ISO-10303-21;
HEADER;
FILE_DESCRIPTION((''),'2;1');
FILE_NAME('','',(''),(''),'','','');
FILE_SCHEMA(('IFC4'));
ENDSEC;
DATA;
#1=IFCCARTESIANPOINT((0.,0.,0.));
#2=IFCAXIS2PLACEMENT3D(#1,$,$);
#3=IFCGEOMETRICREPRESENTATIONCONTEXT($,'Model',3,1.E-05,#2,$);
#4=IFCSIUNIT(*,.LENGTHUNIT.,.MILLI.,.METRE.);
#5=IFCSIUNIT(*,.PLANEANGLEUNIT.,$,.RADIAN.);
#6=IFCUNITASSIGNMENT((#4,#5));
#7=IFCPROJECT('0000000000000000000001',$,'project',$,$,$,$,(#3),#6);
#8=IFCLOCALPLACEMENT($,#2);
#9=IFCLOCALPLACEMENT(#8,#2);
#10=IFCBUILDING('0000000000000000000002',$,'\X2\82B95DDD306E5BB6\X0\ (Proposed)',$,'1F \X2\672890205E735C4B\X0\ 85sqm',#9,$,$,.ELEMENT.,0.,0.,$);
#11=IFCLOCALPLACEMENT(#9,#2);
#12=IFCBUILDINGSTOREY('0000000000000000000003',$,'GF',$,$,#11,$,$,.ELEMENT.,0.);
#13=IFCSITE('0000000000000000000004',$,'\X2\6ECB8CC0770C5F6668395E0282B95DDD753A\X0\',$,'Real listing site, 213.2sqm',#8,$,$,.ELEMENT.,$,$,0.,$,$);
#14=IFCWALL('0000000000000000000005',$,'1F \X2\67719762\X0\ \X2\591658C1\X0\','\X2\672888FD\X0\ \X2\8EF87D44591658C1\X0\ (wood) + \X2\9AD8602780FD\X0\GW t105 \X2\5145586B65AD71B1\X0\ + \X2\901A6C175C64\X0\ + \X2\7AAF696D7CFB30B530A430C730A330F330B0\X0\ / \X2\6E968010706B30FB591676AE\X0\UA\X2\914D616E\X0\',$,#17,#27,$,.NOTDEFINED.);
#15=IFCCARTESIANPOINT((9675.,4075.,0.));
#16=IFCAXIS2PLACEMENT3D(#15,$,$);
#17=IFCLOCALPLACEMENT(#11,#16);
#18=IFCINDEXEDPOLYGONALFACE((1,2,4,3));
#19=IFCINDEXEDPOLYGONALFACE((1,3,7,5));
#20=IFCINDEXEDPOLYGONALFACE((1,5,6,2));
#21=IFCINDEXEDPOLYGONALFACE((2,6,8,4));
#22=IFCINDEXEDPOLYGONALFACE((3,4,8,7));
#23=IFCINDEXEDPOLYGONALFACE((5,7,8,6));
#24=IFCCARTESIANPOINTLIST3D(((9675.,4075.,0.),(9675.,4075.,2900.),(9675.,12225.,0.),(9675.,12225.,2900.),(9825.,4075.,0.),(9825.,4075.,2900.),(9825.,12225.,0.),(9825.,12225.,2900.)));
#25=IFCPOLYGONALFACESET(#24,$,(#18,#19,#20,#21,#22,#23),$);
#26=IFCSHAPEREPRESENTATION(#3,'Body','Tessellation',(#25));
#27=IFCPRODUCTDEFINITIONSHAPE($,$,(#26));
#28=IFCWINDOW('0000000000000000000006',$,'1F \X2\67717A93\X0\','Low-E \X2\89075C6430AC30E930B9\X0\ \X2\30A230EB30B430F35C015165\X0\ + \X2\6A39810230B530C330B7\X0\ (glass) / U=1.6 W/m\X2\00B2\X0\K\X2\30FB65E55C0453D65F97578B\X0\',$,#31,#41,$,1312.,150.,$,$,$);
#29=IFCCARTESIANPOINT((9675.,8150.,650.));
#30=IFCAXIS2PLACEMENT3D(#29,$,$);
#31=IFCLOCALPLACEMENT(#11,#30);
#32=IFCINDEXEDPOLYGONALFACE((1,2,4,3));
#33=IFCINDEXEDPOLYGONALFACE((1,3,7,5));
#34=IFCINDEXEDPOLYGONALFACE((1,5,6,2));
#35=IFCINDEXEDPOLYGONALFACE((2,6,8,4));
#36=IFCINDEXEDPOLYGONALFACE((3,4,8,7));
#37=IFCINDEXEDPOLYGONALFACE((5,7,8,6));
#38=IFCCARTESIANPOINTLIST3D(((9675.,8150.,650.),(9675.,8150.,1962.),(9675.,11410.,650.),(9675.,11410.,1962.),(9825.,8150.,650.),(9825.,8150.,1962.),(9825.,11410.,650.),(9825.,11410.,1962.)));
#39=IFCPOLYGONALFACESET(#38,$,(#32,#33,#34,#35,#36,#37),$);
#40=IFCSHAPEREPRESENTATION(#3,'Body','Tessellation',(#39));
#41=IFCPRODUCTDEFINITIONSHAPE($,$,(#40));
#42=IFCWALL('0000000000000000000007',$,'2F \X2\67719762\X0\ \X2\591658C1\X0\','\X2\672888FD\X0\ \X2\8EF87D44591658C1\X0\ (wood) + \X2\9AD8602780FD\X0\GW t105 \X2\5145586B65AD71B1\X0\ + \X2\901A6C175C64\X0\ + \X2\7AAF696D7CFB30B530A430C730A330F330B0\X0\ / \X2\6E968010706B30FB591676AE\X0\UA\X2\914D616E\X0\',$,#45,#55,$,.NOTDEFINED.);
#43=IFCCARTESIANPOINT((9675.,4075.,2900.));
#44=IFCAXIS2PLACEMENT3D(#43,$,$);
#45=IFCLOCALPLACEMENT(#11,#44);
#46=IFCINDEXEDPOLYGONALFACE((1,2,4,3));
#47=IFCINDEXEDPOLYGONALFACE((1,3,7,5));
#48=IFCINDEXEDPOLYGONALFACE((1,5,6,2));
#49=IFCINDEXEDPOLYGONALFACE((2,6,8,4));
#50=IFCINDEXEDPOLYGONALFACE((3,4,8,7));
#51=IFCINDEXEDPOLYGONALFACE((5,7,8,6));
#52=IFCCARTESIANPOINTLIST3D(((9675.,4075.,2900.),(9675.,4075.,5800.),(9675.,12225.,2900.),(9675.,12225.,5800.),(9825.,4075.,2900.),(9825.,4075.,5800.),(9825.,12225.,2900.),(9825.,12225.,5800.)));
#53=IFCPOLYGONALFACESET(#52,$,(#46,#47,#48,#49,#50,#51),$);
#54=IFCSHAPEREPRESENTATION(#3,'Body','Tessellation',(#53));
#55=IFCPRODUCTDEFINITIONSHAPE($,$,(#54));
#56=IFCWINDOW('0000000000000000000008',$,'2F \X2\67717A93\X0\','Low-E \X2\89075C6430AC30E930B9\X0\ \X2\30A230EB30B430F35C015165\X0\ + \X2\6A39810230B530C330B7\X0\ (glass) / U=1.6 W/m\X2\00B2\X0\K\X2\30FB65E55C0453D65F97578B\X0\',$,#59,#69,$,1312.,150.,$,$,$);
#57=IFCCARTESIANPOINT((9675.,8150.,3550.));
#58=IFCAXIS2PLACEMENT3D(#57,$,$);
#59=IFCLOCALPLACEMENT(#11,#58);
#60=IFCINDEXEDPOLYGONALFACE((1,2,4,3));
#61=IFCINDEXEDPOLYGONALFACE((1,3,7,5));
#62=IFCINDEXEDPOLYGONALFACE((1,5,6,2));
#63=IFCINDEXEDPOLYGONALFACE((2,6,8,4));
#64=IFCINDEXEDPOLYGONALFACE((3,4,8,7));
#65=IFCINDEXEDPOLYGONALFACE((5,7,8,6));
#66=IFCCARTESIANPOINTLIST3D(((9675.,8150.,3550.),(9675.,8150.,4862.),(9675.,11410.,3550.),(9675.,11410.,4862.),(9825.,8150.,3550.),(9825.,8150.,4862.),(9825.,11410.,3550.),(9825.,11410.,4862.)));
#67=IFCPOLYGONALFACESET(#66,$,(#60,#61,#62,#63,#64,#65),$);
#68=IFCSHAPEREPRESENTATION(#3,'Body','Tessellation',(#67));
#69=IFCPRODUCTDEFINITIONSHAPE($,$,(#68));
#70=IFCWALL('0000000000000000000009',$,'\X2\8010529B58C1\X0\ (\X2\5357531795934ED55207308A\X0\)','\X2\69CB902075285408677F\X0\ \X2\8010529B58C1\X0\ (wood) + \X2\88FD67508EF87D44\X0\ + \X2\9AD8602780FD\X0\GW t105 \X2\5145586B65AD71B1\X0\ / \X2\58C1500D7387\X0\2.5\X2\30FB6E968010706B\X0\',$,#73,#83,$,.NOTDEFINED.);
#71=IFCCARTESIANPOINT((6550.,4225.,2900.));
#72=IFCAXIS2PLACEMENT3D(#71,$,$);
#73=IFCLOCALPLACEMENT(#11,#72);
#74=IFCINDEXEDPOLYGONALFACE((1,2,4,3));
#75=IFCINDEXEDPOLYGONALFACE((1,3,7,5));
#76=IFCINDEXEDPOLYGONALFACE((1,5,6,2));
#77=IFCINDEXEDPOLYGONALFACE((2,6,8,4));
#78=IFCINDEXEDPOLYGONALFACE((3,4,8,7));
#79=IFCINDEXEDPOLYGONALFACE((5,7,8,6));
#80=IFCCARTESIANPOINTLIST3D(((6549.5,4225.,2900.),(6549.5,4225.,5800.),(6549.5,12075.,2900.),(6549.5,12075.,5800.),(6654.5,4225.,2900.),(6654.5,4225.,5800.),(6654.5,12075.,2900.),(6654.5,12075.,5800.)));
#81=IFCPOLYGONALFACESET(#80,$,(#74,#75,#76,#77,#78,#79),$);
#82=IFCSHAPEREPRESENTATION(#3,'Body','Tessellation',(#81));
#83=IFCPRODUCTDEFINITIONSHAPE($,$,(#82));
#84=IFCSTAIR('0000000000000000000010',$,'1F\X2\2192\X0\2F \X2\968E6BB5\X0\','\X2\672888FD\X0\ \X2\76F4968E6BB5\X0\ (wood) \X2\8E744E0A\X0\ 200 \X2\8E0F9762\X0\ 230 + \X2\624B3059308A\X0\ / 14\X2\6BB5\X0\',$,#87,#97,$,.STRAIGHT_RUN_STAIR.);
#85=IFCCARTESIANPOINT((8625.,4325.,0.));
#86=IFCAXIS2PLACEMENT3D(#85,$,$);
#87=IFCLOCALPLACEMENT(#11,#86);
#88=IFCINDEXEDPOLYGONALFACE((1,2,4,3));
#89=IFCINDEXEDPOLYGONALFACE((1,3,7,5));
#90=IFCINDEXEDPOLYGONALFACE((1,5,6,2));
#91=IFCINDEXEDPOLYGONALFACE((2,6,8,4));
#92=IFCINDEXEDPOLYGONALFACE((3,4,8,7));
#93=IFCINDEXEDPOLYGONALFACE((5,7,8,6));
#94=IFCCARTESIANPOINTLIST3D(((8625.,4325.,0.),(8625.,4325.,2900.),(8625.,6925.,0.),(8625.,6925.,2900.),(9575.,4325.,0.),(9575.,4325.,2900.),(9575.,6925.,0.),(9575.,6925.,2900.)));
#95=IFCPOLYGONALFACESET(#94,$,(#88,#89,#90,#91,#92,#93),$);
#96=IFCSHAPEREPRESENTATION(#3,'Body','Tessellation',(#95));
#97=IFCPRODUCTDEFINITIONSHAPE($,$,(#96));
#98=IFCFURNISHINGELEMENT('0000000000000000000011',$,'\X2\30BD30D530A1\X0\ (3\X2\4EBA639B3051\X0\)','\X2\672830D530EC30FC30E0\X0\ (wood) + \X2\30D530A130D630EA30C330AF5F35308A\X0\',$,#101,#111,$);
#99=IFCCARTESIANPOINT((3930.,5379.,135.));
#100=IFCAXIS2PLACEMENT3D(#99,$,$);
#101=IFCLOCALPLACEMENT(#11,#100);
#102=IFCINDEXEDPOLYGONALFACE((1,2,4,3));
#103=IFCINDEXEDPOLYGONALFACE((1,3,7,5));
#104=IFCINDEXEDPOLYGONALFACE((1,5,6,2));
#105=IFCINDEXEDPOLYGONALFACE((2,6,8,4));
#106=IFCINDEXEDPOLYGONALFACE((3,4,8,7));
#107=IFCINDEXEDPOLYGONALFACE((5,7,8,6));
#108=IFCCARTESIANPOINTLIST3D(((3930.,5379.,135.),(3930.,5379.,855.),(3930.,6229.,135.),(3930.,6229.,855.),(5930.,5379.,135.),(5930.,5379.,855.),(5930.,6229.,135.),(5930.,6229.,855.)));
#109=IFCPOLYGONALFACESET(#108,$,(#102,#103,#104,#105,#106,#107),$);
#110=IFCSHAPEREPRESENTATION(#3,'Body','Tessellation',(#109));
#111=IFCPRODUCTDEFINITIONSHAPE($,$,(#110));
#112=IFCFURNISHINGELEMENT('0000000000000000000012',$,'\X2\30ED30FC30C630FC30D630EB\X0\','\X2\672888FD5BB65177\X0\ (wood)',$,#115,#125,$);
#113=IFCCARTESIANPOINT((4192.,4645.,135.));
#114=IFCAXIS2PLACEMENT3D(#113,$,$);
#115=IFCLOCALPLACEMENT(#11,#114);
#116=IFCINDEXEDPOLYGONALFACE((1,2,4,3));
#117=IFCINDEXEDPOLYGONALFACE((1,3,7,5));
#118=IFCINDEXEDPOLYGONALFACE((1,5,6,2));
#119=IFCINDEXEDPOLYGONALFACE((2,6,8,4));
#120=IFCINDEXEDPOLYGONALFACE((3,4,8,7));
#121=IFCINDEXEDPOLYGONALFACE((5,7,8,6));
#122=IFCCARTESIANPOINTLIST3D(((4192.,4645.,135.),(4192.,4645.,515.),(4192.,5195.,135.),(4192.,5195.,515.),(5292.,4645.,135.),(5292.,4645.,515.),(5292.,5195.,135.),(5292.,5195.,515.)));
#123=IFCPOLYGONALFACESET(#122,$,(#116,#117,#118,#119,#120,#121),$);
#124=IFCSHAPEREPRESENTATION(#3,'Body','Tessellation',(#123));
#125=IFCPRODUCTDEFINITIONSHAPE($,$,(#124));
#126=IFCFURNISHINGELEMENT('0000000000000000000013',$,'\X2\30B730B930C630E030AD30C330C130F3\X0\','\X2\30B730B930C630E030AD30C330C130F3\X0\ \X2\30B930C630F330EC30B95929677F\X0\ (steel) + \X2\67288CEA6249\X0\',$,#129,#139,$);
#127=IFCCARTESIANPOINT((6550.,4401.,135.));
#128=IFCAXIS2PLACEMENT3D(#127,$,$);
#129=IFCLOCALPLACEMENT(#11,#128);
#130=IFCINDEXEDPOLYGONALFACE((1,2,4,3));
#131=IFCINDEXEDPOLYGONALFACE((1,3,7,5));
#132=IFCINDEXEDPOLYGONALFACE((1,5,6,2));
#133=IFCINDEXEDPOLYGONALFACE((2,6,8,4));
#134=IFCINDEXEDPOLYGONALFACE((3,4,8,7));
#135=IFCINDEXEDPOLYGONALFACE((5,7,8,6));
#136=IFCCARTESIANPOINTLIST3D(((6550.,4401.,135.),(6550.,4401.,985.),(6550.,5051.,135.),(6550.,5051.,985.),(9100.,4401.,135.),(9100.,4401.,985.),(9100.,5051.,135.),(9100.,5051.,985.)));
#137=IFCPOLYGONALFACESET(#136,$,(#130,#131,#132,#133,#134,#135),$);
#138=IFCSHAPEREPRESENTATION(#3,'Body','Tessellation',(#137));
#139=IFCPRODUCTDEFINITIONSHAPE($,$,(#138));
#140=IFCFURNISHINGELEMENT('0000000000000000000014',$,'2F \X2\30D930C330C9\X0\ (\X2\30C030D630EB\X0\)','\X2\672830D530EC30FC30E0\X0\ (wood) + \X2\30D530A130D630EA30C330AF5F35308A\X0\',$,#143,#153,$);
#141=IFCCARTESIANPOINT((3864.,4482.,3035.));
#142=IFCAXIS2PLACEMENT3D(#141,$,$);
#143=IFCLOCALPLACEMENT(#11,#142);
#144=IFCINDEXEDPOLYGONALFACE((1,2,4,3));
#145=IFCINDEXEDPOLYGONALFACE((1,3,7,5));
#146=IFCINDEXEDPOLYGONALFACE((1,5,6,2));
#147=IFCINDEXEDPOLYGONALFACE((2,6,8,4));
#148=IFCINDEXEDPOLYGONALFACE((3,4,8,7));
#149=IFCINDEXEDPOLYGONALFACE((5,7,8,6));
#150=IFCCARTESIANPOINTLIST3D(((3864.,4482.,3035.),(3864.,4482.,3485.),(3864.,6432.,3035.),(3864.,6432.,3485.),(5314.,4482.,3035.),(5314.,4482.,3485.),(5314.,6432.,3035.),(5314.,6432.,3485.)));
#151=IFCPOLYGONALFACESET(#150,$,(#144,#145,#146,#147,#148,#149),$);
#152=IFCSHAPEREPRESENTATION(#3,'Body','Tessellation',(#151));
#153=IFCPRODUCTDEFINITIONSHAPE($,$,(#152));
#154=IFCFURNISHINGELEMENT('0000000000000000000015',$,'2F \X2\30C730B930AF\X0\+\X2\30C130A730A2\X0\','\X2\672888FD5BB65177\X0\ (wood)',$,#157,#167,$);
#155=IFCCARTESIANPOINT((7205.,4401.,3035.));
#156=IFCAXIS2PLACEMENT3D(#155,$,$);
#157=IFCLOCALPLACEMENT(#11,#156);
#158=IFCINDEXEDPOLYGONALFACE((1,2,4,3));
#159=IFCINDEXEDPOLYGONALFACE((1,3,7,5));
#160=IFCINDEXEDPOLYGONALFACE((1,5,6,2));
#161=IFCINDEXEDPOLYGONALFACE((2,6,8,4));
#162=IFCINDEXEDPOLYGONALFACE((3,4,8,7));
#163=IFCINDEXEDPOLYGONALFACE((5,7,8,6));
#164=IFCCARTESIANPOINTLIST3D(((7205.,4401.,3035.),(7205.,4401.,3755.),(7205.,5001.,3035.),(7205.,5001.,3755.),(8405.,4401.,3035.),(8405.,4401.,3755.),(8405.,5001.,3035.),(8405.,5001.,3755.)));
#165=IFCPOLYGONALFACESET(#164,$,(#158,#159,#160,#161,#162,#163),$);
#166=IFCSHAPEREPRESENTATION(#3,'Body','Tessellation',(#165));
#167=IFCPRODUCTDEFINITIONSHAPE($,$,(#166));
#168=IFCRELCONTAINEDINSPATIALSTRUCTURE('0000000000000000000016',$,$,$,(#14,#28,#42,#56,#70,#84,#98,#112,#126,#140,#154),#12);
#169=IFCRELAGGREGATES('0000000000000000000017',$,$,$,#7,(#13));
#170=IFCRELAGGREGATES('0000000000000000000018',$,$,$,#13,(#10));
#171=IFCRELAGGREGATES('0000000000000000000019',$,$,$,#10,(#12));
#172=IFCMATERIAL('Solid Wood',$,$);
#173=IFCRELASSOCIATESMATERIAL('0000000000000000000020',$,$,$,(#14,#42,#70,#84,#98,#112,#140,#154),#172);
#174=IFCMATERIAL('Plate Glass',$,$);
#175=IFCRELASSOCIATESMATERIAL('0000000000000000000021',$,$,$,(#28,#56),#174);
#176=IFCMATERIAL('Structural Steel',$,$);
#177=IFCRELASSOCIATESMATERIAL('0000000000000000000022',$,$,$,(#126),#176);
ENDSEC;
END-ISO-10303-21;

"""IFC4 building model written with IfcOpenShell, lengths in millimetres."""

from ifc_helpers import new_model, si_unit, frame, frame_2d, origin, place, context, project, spatial, rectangle, extrude, material, element, fill, save


model = new_model("IFC4")

# Units and contexts
model_context = context("Model", 3, precision=1e-05, world=origin())
ifc_project = project(units=[si_unit("LENGTHUNIT", "METRE", prefix="MILLI"), si_unit("PLANEANGLEUNIT", "RADIAN")], contexts=[model_context])

# Site, building, storey
site_placement = place(None, origin())
site = spatial("IfcSite", under=ifc_project, at=site_placement, Name="滋賀県彦根市芹川町", ObjectType="Real listing site, 213.2sqm", CompositionType="ELEMENT", RefElevation=0.0)
building_placement = place(site_placement, origin())
building = spatial("IfcBuilding", under=site, at=building_placement, Name="芹川の家 (Proposed)", ObjectType="1F 木造平屋 85sqm", CompositionType="ELEMENT", ElevationOfRefHeight=0.0, ElevationOfTerrain=0.0)
storey_placement = place(building_placement, origin())
storey = spatial("IfcBuildingStorey", under=building, at=storey_placement, Name="GF", CompositionType="ELEMENT", Elevation=0.0)

# Wall, opening, window
ifc_material_1 = material(Name="Solid Wood")
wall_1_placement = place(storey_placement, frame((9675.0, 4075.0, 0.0)))
wall_1 = element("IfcWall", 1, at=wall_1_placement, inside=storey, material=ifc_material_1, Name="1F 東面 外壁", Description="木製 軸組外壁 (wood) + 高性能GW t105 充填断熱 + 通気層 + 窯業系サイディング / 準耐火・外皮UA配慮", PredefinedType="NOTDEFINED", context=model_context, shape_type="SweptSolid", body=[
    extrude(rectangle(XDim=150.0, YDim=8150.0, at=frame_2d((75.0, 4075.0))), frame((9675.0, 4075.0, 0.0)), (0.0, 0.0, 1.0), 2900.0),
])
opening_1_placement = place(storey_placement, frame((9675.0, 8150.0, 650.0)))
opening_1 = element("IfcOpeningElement", 2, at=opening_1_placement, cuts=wall_1, PredefinedType="NOTDEFINED", context=model_context, shape_type="SweptSolid", body=[
    extrude(rectangle(XDim=150.0, YDim=3260.0, at=frame_2d((75.0, 1630.0))), frame((9675.0, 8150.0, 650.0)), (0.0, 0.0, 1.0), 1312.0),
])
ifc_material_2 = material(Name="Plate Glass")
window_1_placement = place(storey_placement, frame((9675.0, 8150.0, 650.0)))
window_1 = element("IfcWindow", 3, at=window_1_placement, inside=storey, material=ifc_material_2, Name="1F 東窓", Description="Low-E 複層ガラス アルゴン封入 + 樹脂サッシ (glass) / U=1.6 W/m²K・日射取得型", OverallHeight=1312.0, OverallWidth=150.0, context=model_context, shape_type="SweptSolid", body=[
    extrude(rectangle(XDim=150.0, YDim=3260.0, at=frame_2d((75.0, 1630.0))), frame((9675.0, 8150.0, 650.0)), (0.0, 0.0, 1.0), 1312.0),
])
fill(opening_1, window_1)

# Wall, opening, window
wall_2_placement = place(storey_placement, frame((9675.0, 4075.0, 2900.0)))
wall_2 = element("IfcWall", 4, at=wall_2_placement, inside=storey, material=ifc_material_1, Name="2F 東面 外壁", Description="木製 軸組外壁 (wood) + 高性能GW t105 充填断熱 + 通気層 + 窯業系サイディング / 準耐火・外皮UA配慮", PredefinedType="NOTDEFINED", context=model_context, shape_type="SweptSolid", body=[
    extrude(rectangle(XDim=150.0, YDim=8150.0, at=frame_2d((75.0, 4075.0))), frame((9675.0, 4075.0, 2900.0)), (0.0, 0.0, 1.0), 2900.0),
])
opening_2_placement = place(storey_placement, frame((9675.0, 8150.0, 3550.0)))
opening_2 = element("IfcOpeningElement", 5, at=opening_2_placement, cuts=wall_2, PredefinedType="NOTDEFINED", context=model_context, shape_type="SweptSolid", body=[
    extrude(rectangle(XDim=150.0, YDim=3260.0, at=frame_2d((75.0, 1630.0))), frame((9675.0, 8150.0, 3550.0)), (0.0, 0.0, 1.0), 1312.0),
])
window_2_placement = place(storey_placement, frame((9675.0, 8150.0, 3550.0)))
window_2 = element("IfcWindow", 6, at=window_2_placement, inside=storey, material=ifc_material_2, Name="2F 東窓", Description="Low-E 複層ガラス アルゴン封入 + 樹脂サッシ (glass) / U=1.6 W/m²K・日射取得型", OverallHeight=1312.0, OverallWidth=150.0, context=model_context, shape_type="SweptSolid", body=[
    extrude(rectangle(XDim=150.0, YDim=3260.0, at=frame_2d((75.0, 1630.0))), frame((9675.0, 8150.0, 3550.0)), (0.0, 0.0, 1.0), 1312.0),
])
fill(opening_2, window_2)

# Wall
wall_3_placement = place(storey_placement, frame((6550.0, 4225.0, 2900.0)))
element("IfcWall", 7, at=wall_3_placement, inside=storey, material=ifc_material_1, Name="耐力壁 (南北間仕切り)", Description="構造用合板 耐力壁 (wood) + 製材軸組 + 高性能GW t105 充填断熱 / 壁倍率2.5・準耐火", PredefinedType="NOTDEFINED", context=model_context, shape_type="SweptSolid", body=[
    extrude(rectangle(XDim=105.0, YDim=7850.0, at=frame_2d((52.0, 3925.0))), frame((6550.0, 4225.0, 2900.0)), (0.0, 0.0, 1.0), 2900.0),
])

# Stair
stair_placement = place(storey_placement, frame((8625.0, 4325.0, 0.0)))
element("IfcStair", 8, at=stair_placement, inside=storey, material=ifc_material_1, Name="1F→2F 階段", Description="木製 直階段 (wood) 蹴上 200 踏面 230 + 手すり / 14段", PredefinedType="STRAIGHT_RUN_STAIR", context=model_context, shape_type="SweptSolid", body=[
    extrude(rectangle(XDim=950.0, YDim=2600.0, at=frame_2d((475.0, 1300.0))), frame((8625.0, 4325.0, 0.0)), (0.0, 0.0, 1.0), 2900.0),
])

# Furnishing elements
furnishing_1_placement = place(storey_placement, frame((3930.0, 5379.0, 135.0)))
element("IfcFurnishingElement", 9, at=furnishing_1_placement, inside=storey, material=ifc_material_1, Name="ソファ (3人掛け)", Description="木フレーム (wood) + ファブリック張り", context=model_context, shape_type="SweptSolid", body=[
    extrude(rectangle(XDim=2000.0, YDim=850.0, at=frame_2d((1000.0, 425.0))), frame((3930.0, 5379.0, 135.0)), (0.0, 0.0, 1.0), 720.0),
])
furnishing_2_placement = place(storey_placement, frame((4192.0, 4645.0, 135.0)))
element("IfcFurnishingElement", 10, at=furnishing_2_placement, inside=storey, material=ifc_material_1, Name="ローテーブル", Description="木製家具 (wood)", context=model_context, shape_type="SweptSolid", body=[
    extrude(rectangle(XDim=1100.0, YDim=550.0, at=frame_2d((550.0, 275.0))), frame((4192.0, 4645.0, 135.0)), (0.0, 0.0, 1.0), 380.0),
])
ifc_material_3 = material(Name="Structural Steel")
furnishing_3_placement = place(storey_placement, frame((6550.0, 4401.0, 135.0)))
element("IfcFurnishingElement", 11, at=furnishing_3_placement, inside=storey, material=ifc_material_3, Name="システムキッチン", Description="システムキッチン ステンレス天板 (steel) + 木質扉", context=model_context, shape_type="SweptSolid", body=[
    extrude(rectangle(XDim=2550.0, YDim=650.0, at=frame_2d((1275.0, 325.0))), frame((6550.0, 4401.0, 135.0)), (0.0, 0.0, 1.0), 850.0),
])
furnishing_4_placement = place(storey_placement, frame((3864.0, 4482.0, 3035.0)))
element("IfcFurnishingElement", 12, at=furnishing_4_placement, inside=storey, material=ifc_material_1, Name="2F ベッド (ダブル)", Description="木フレーム (wood) + ファブリック張り", context=model_context, shape_type="SweptSolid", body=[
    extrude(rectangle(XDim=1450.0, YDim=1950.0, at=frame_2d((725.0, 975.0))), frame((3864.0, 4482.0, 3035.0)), (0.0, 0.0, 1.0), 450.0),
])
furnishing_5_placement = place(storey_placement, frame((7205.0, 4401.0, 3035.0)))
element("IfcFurnishingElement", 13, at=furnishing_5_placement, inside=storey, material=ifc_material_1, Name="2F デスク+チェア", Description="木製家具 (wood)", context=model_context, shape_type="SweptSolid", body=[
    extrude(rectangle(XDim=1200.0, YDim=600.0, at=frame_2d((600.0, 300.0))), frame((7205.0, 4401.0, 3035.0)), (0.0, 0.0, 1.0), 720.0),
])

save(model, "model.ifc")
